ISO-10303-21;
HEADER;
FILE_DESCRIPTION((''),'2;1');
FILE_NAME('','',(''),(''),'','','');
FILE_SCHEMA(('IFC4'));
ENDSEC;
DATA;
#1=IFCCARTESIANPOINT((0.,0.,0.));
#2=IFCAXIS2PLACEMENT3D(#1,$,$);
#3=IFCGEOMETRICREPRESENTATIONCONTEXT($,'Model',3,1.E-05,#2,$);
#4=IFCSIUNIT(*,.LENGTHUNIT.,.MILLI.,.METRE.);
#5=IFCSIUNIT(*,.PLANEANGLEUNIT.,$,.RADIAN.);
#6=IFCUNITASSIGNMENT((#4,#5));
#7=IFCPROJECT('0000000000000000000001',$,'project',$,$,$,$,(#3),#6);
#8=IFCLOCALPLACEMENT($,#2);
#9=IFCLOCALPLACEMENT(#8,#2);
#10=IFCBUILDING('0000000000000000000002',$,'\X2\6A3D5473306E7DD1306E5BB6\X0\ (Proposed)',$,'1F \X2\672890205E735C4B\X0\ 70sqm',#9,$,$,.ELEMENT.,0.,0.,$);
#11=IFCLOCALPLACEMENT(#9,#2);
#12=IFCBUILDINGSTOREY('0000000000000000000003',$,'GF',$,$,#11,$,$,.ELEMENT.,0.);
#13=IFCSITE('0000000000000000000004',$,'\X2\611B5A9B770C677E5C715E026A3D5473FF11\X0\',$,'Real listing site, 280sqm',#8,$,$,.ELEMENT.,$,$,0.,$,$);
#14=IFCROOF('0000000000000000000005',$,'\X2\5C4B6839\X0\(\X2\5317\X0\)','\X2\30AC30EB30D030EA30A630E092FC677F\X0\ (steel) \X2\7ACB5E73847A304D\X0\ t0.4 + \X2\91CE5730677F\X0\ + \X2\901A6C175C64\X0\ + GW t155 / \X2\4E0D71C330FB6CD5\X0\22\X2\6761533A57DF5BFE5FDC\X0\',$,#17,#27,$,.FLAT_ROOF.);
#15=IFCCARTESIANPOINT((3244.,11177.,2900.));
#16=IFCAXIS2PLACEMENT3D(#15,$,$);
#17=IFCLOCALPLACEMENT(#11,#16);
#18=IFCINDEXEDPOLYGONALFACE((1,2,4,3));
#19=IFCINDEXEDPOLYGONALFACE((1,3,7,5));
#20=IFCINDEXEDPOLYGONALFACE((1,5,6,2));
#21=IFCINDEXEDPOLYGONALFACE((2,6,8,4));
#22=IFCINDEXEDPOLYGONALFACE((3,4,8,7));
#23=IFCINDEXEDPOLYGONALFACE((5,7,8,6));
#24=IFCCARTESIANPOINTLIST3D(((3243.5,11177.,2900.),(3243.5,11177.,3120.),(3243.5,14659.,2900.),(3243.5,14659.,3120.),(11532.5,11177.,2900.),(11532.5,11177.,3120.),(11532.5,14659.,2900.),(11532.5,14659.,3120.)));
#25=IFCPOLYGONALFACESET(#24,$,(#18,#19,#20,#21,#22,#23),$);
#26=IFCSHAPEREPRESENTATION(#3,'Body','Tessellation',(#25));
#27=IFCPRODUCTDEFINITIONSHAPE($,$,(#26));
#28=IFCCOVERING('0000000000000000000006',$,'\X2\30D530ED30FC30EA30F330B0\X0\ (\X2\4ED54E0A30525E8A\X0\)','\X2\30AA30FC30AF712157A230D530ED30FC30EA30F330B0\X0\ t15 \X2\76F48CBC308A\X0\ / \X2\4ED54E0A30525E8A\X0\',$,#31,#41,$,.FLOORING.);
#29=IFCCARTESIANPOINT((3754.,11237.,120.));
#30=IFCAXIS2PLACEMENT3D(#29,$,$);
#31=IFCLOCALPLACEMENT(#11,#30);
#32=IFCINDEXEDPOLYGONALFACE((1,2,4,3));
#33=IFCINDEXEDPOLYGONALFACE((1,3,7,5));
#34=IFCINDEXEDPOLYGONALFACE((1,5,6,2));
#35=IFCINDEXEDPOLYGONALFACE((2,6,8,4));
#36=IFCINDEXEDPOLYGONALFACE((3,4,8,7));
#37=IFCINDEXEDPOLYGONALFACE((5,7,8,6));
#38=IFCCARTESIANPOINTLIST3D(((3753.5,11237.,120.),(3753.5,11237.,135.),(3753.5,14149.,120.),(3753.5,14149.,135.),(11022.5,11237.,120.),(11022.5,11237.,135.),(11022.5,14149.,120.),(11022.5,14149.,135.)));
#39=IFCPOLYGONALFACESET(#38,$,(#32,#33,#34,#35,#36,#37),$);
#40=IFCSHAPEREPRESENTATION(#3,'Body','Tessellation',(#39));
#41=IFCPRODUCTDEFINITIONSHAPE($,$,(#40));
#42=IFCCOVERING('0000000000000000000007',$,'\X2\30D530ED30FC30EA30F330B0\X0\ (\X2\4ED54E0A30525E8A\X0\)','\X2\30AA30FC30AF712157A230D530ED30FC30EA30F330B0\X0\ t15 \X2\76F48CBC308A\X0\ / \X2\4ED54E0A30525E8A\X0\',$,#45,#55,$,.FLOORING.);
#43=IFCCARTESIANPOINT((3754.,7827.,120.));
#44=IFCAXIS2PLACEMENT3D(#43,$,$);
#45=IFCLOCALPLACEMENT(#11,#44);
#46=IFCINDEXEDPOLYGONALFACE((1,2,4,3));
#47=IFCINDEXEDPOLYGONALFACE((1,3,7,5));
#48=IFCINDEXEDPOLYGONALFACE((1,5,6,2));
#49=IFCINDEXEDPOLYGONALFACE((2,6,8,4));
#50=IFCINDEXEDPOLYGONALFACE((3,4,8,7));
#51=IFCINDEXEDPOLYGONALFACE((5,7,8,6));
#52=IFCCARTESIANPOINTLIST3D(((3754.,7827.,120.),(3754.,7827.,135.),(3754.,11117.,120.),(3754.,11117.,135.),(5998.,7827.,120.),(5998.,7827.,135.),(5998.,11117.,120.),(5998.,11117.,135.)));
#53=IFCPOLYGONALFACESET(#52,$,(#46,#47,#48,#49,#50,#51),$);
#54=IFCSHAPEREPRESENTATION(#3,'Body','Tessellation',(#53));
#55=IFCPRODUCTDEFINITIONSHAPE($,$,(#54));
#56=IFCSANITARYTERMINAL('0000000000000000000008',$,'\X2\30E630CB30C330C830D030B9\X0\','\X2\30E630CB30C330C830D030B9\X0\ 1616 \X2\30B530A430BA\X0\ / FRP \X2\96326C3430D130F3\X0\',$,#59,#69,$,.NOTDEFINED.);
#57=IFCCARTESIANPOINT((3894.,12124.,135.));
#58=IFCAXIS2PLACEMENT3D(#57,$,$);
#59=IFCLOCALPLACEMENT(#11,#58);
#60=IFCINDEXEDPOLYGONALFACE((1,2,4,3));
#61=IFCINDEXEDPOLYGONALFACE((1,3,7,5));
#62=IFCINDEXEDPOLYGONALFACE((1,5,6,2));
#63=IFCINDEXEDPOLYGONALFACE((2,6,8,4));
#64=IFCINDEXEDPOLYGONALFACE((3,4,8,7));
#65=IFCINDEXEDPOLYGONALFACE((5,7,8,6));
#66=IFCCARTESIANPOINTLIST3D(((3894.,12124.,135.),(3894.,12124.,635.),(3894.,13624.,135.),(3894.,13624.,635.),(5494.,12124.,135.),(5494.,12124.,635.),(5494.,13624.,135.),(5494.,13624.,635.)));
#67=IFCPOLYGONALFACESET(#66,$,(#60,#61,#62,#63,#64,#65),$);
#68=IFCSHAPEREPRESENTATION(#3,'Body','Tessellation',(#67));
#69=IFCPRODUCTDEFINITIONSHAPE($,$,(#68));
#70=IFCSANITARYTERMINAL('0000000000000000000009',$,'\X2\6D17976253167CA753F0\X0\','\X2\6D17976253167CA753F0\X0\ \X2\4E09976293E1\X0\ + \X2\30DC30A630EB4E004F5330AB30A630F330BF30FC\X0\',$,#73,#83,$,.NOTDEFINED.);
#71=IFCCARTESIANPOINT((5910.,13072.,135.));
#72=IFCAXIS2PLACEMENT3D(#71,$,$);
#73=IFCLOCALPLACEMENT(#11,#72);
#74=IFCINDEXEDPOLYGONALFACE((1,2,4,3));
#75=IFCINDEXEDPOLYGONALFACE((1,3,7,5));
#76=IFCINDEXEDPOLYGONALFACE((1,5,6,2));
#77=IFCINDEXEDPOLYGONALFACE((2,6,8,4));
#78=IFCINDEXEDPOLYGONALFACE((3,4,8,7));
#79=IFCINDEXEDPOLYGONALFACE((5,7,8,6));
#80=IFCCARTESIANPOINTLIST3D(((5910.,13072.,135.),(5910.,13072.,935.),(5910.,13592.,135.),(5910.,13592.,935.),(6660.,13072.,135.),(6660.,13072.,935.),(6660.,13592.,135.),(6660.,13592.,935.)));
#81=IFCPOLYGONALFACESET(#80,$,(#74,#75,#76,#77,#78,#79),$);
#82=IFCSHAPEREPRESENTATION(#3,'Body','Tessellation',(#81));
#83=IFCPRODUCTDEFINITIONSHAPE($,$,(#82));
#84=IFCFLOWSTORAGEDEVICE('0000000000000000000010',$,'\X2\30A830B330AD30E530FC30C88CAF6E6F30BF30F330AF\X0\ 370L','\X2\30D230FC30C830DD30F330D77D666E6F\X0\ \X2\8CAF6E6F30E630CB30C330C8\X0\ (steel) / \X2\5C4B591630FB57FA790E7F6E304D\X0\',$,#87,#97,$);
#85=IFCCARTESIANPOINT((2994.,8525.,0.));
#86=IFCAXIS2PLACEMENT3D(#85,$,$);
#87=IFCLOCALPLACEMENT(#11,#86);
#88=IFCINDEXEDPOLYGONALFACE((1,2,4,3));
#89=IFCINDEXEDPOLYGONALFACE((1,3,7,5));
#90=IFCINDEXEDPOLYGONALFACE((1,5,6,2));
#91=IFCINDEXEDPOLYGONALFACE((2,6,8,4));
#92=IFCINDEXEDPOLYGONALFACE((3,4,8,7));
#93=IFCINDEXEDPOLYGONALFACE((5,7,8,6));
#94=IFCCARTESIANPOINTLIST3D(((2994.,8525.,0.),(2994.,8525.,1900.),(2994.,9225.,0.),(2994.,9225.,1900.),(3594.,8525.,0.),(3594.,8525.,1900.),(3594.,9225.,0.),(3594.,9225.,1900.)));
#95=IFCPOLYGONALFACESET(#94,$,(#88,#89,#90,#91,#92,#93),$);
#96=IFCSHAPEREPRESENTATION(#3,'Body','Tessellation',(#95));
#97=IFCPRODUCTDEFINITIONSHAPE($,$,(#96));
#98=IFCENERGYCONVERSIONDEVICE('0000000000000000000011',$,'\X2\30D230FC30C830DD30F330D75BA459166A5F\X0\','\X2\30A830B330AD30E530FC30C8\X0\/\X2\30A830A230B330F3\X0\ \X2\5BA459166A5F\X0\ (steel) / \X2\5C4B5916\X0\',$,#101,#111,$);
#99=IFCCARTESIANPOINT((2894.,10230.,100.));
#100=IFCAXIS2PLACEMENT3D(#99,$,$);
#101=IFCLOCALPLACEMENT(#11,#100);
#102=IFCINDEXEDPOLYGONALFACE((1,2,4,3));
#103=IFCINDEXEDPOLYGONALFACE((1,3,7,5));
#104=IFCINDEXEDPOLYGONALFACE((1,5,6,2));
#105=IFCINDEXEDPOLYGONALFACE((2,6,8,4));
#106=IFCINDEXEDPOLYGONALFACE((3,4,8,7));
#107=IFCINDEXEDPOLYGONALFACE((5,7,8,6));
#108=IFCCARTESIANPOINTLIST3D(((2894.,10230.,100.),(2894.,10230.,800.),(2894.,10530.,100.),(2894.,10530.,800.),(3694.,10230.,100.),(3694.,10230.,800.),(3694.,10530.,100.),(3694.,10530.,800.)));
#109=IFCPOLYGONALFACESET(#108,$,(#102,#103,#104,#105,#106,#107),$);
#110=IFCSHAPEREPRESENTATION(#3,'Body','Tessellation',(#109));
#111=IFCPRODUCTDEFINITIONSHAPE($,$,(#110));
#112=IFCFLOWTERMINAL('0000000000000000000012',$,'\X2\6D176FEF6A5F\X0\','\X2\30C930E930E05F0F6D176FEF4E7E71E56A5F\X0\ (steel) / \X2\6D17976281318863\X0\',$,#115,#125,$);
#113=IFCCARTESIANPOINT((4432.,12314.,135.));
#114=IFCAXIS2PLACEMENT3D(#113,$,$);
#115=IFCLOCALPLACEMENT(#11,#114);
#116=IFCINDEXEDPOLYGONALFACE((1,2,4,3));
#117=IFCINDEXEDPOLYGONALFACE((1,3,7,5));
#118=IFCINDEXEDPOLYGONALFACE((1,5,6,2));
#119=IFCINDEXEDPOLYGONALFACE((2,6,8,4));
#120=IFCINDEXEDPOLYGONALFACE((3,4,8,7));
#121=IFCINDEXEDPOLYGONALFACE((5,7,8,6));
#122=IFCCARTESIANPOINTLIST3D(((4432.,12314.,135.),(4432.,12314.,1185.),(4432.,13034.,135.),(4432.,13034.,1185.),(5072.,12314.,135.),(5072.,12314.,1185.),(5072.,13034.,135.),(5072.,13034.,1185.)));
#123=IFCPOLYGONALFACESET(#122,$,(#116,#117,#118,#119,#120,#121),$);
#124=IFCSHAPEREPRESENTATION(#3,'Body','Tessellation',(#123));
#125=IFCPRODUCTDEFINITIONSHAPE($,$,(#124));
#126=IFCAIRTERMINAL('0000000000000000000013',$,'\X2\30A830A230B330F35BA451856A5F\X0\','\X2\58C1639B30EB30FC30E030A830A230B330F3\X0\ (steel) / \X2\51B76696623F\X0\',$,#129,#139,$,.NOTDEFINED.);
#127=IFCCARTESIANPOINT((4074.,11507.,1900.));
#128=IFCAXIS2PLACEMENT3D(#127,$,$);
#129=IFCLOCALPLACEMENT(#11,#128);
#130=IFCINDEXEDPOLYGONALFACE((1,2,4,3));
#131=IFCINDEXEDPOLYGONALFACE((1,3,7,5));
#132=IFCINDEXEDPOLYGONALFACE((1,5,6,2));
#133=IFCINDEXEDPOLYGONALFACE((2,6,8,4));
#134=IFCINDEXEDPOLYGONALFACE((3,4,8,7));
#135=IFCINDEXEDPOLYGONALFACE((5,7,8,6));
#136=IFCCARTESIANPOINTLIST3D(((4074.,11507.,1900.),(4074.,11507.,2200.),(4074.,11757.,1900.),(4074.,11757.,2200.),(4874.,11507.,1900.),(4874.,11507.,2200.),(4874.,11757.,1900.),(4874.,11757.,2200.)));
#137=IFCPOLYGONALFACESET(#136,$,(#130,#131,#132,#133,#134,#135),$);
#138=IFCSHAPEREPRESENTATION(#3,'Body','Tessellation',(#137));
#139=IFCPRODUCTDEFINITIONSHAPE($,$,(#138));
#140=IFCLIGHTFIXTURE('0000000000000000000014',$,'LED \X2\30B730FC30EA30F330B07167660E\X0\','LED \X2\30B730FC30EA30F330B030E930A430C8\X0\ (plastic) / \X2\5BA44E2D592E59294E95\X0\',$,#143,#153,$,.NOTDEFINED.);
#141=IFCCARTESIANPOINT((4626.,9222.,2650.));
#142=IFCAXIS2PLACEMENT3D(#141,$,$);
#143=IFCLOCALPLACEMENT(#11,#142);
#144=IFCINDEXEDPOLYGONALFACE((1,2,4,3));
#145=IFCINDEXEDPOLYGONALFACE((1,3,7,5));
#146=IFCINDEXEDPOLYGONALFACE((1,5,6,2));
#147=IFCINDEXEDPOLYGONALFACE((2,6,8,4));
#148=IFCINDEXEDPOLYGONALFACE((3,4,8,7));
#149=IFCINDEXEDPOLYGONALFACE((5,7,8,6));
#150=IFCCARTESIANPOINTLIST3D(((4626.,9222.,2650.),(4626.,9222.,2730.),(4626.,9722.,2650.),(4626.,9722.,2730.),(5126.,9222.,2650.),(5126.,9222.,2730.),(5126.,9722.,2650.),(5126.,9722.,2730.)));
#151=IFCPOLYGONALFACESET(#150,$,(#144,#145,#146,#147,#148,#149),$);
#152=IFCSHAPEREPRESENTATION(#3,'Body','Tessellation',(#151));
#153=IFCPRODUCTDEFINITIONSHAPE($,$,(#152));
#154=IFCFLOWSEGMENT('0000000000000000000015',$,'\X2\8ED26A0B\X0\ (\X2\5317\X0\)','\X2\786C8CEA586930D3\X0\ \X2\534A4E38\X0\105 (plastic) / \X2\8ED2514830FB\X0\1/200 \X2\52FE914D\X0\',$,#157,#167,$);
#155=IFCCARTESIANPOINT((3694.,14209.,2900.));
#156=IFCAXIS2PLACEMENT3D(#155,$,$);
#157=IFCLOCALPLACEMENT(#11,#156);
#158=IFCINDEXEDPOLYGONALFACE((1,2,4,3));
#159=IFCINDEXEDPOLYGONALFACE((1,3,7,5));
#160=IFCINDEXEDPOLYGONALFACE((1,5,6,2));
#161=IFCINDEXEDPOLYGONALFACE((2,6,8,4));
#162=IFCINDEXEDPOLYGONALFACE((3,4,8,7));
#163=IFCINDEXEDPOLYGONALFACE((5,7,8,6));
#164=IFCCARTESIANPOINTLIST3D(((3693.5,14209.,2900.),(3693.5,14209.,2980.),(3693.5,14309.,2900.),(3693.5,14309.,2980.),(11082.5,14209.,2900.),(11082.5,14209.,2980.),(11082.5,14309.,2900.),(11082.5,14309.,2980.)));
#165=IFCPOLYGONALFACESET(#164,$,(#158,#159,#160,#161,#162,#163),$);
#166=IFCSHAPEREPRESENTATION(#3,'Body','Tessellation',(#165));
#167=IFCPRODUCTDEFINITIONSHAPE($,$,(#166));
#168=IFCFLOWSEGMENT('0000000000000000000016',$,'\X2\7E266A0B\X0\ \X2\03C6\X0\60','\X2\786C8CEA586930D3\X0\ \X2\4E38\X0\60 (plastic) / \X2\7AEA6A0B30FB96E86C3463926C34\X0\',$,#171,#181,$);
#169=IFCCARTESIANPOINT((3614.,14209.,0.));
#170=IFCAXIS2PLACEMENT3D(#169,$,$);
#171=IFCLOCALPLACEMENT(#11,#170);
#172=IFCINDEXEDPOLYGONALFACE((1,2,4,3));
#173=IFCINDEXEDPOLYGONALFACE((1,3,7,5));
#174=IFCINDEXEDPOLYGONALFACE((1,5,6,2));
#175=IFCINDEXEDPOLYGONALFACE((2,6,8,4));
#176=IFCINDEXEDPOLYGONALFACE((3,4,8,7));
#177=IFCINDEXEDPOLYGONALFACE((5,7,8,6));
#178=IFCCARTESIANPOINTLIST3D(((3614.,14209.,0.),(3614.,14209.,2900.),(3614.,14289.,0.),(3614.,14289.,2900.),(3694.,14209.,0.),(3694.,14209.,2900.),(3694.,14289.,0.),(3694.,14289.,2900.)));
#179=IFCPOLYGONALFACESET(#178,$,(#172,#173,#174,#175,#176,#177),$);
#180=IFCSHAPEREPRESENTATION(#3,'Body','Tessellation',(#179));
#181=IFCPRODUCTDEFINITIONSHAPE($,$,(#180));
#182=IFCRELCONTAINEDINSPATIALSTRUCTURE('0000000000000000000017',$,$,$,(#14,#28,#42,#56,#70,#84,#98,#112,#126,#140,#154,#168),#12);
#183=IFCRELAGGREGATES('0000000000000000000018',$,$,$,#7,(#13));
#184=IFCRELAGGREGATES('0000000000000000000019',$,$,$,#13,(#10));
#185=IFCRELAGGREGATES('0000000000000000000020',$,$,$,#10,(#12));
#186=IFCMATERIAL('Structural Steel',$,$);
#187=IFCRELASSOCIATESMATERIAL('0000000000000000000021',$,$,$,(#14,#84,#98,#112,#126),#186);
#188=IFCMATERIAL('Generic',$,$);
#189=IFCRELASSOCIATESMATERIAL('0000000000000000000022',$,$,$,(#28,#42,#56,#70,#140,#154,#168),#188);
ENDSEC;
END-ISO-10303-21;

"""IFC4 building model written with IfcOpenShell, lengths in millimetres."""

from ifc_helpers import new_model, si_unit, frame, frame_2d, origin, place, context, project, spatial, rectangle, extrude, material, element, save


model = new_model("IFC4")

# Units and contexts
model_context = context("Model", 3, precision=1e-05, world=origin())
ifc_project = project(units=[si_unit("LENGTHUNIT", "METRE", prefix="MILLI"), si_unit("PLANEANGLEUNIT", "RADIAN")], contexts=[model_context])

# Site, building, storey
site_placement = place(None, origin())
site = spatial("IfcSite", under=ifc_project, at=site_placement, Name="愛媛県松山市樽味１", ObjectType="Real listing site, 280sqm", CompositionType="ELEMENT", RefElevation=0.0)
building_placement = place(site_placement, origin())
building = spatial("IfcBuilding", under=site, at=building_placement, Name="樽味の緑の家 (Proposed)", ObjectType="1F 木造平屋 70sqm", CompositionType="ELEMENT", ElevationOfRefHeight=0.0, ElevationOfTerrain=0.0)
storey_placement = place(building_placement, origin())
storey = spatial("IfcBuildingStorey", under=building, at=storey_placement, Name="GF", CompositionType="ELEMENT", Elevation=0.0)

# Roof
ifc_material_1 = material(Name="Structural Steel")
roof_placement = place(storey_placement, frame((3244.0, 11177.0, 2900.0)))
element("IfcRoof", 1, at=roof_placement, inside=storey, material=ifc_material_1, Name="屋根(北)", Description="ガルバリウム鋼板 (steel) 立平葺き t0.4 + 野地板 + 通気層 + GW t155 / 不燃・法22条区域対応", PredefinedType="FLAT_ROOF", context=model_context, shape_type="SweptSolid", body=[
    extrude(rectangle(XDim=8289.0, YDim=3482.0, at=frame_2d((4144.0, 1741.0))), frame((3244.0, 11177.0, 2900.0)), (0.0, 0.0, 1.0), 220.0),
])

# Coverings
ifc_material_2 = material(Name="Generic")
covering_1_placement = place(storey_placement, frame((3754.0, 11237.0, 120.0)))
element("IfcCovering", 2, at=covering_1_placement, inside=storey, material=ifc_material_2, Name="フローリング (仕上げ床)", Description="オーク無垢フローリング t15 直貼り / 仕上げ床", PredefinedType="FLOORING", context=model_context, shape_type="SweptSolid", body=[
    extrude(rectangle(XDim=7269.0, YDim=2912.0, at=frame_2d((3634.0, 1456.0))), frame((3754.0, 11237.0, 120.0)), (0.0, 0.0, 1.0), 15.0),
])
covering_2_placement = place(storey_placement, frame((3754.0, 7827.0, 120.0)))
element("IfcCovering", 3, at=covering_2_placement, inside=storey, material=ifc_material_2, Name="フローリング (仕上げ床)", Description="オーク無垢フローリング t15 直貼り / 仕上げ床", PredefinedType="FLOORING", context=model_context, shape_type="SweptSolid", body=[
    extrude(rectangle(XDim=2244.0, YDim=3290.0, at=frame_2d((1122.0, 1645.0))), frame((3754.0, 7827.0, 120.0)), (0.0, 0.0, 1.0), 15.0),
])

# Sanitary terminals
sanitary_terminal_1_placement = place(storey_placement, frame((3894.0, 12124.0, 135.0)))
element("IfcSanitaryTerminal", 4, at=sanitary_terminal_1_placement, inside=storey, material=ifc_material_2, Name="ユニットバス", Description="ユニットバス 1616 サイズ / FRP 防水パン", PredefinedType="NOTDEFINED", context=model_context, shape_type="SweptSolid", body=[
    extrude(rectangle(XDim=1600.0, YDim=1500.0, at=frame_2d((800.0, 750.0))), frame((3894.0, 12124.0, 135.0)), (0.0, 0.0, 1.0), 500.0),
])
sanitary_terminal_2_placement = place(storey_placement, frame((5910.0, 13072.0, 135.0)))
element("IfcSanitaryTerminal", 5, at=sanitary_terminal_2_placement, inside=storey, material=ifc_material_2, Name="洗面化粧台", Description="洗面化粧台 三面鏡 + ボウル一体カウンター", PredefinedType="NOTDEFINED", context=model_context, shape_type="SweptSolid", body=[
    extrude(rectangle(XDim=750.0, YDim=520.0, at=frame_2d((375.0, 260.0))), frame((5910.0, 13072.0, 135.0)), (0.0, 0.0, 1.0), 800.0),
])

# Flow storage device
flow_storage_device_placement = place(storey_placement, frame((2994.0, 8525.0, 0.0)))
element("IfcFlowStorageDevice", 6, at=flow_storage_device_placement, inside=storey, material=ifc_material_1, Name="エコキュート貯湯タンク 370L", Description="ヒートポンプ給湯 貯湯ユニット (steel) / 屋外・基礎置き", context=model_context, shape_type="SweptSolid", body=[
    extrude(rectangle(XDim=600.0, YDim=700.0, at=frame_2d((300.0, 350.0))), frame((2994.0, 8525.0, 0.0)), (0.0, 0.0, 1.0), 1900.0),
])

# Energy conversion device
energy_conversion_device_placement = place(storey_placement, frame((2894.0, 10230.0, 100.0)))
element("IfcEnergyConversionDevice", 7, at=energy_conversion_device_placement, inside=storey, material=ifc_material_1, Name="ヒートポンプ室外機", Description="エコキュート/エアコン 室外機 (steel) / 屋外", context=model_context, shape_type="SweptSolid", body=[
    extrude(rectangle(XDim=800.0, YDim=300.0, at=frame_2d((400.0, 150.0))), frame((2894.0, 10230.0, 100.0)), (0.0, 0.0, 1.0), 700.0),
])

# Flow terminal
flow_terminal_placement = place(storey_placement, frame((4432.0, 12314.0, 135.0)))
element("IfcFlowTerminal", 8, at=flow_terminal_placement, inside=storey, material=ifc_material_1, Name="洗濯機", Description="ドラム式洗濯乾燥機 (steel) / 洗面脱衣", context=model_context, shape_type="SweptSolid", body=[
    extrude(rectangle(XDim=640.0, YDim=720.0, at=frame_2d((320.0, 360.0))), frame((4432.0, 12314.0, 135.0)), (0.0, 0.0, 1.0), 1050.0),
])

# Air terminal
air_terminal_placement = place(storey_placement, frame((4074.0, 11507.0, 1900.0)))
element("IfcAirTerminal", 9, at=air_terminal_placement, inside=storey, material=ifc_material_1, Name="エアコン室内機", Description="壁掛ルームエアコン (steel) / 冷暖房", PredefinedType="NOTDEFINED", context=model_context, shape_type="SweptSolid", body=[
    extrude(rectangle(XDim=800.0, YDim=250.0, at=frame_2d((400.0, 125.0))), frame((4074.0, 11507.0, 1900.0)), (0.0, 0.0, 1.0), 300.0),
])

# Light fixture
light_fixture_placement = place(storey_placement, frame((4626.0, 9222.0, 2650.0)))
element("IfcLightFixture", 10, at=light_fixture_placement, inside=storey, material=ifc_material_2, Name="LED シーリング照明", Description="LED シーリングライト (plastic) / 室中央天井", PredefinedType="NOTDEFINED", context=model_context, shape_type="SweptSolid", body=[
    extrude(rectangle(XDim=500.0, YDim=500.0, at=frame_2d((250.0, 250.0))), frame((4626.0, 9222.0, 2650.0)), (0.0, 0.0, 1.0), 80.0),
])

# Flow segments
flow_segment_1_placement = place(storey_placement, frame((3694.0, 14209.0, 2900.0)))
element("IfcFlowSegment", 11, at=flow_segment_1_placement, inside=storey, material=ifc_material_2, Name="軒樋 (北)", Description="硬質塩ビ 半丸105 (plastic) / 軒先・1/200 勾配", context=model_context, shape_type="SweptSolid", body=[
    extrude(rectangle(XDim=7389.0, YDim=100.0, at=frame_2d((3694.0, 50.0))), frame((3694.0, 14209.0, 2900.0)), (0.0, 0.0, 1.0), 80.0),
])
flow_segment_2_placement = place(storey_placement, frame((3614.0, 14209.0, 0.0)))
element("IfcFlowSegment", 12, at=flow_segment_2_placement, inside=storey, material=ifc_material_2, Name="縦樋 φ60", Description="硬質塩ビ 丸60 (plastic) / 竪樋・雨水排水", context=model_context, shape_type="SweptSolid", body=[
    extrude(rectangle(XDim=80.0, YDim=80.0, at=frame_2d((40.0, 40.0))), frame((3614.0, 14209.0, 0.0)), (0.0, 0.0, 1.0), 2900.0),
])

save(model, "model.ifc")
